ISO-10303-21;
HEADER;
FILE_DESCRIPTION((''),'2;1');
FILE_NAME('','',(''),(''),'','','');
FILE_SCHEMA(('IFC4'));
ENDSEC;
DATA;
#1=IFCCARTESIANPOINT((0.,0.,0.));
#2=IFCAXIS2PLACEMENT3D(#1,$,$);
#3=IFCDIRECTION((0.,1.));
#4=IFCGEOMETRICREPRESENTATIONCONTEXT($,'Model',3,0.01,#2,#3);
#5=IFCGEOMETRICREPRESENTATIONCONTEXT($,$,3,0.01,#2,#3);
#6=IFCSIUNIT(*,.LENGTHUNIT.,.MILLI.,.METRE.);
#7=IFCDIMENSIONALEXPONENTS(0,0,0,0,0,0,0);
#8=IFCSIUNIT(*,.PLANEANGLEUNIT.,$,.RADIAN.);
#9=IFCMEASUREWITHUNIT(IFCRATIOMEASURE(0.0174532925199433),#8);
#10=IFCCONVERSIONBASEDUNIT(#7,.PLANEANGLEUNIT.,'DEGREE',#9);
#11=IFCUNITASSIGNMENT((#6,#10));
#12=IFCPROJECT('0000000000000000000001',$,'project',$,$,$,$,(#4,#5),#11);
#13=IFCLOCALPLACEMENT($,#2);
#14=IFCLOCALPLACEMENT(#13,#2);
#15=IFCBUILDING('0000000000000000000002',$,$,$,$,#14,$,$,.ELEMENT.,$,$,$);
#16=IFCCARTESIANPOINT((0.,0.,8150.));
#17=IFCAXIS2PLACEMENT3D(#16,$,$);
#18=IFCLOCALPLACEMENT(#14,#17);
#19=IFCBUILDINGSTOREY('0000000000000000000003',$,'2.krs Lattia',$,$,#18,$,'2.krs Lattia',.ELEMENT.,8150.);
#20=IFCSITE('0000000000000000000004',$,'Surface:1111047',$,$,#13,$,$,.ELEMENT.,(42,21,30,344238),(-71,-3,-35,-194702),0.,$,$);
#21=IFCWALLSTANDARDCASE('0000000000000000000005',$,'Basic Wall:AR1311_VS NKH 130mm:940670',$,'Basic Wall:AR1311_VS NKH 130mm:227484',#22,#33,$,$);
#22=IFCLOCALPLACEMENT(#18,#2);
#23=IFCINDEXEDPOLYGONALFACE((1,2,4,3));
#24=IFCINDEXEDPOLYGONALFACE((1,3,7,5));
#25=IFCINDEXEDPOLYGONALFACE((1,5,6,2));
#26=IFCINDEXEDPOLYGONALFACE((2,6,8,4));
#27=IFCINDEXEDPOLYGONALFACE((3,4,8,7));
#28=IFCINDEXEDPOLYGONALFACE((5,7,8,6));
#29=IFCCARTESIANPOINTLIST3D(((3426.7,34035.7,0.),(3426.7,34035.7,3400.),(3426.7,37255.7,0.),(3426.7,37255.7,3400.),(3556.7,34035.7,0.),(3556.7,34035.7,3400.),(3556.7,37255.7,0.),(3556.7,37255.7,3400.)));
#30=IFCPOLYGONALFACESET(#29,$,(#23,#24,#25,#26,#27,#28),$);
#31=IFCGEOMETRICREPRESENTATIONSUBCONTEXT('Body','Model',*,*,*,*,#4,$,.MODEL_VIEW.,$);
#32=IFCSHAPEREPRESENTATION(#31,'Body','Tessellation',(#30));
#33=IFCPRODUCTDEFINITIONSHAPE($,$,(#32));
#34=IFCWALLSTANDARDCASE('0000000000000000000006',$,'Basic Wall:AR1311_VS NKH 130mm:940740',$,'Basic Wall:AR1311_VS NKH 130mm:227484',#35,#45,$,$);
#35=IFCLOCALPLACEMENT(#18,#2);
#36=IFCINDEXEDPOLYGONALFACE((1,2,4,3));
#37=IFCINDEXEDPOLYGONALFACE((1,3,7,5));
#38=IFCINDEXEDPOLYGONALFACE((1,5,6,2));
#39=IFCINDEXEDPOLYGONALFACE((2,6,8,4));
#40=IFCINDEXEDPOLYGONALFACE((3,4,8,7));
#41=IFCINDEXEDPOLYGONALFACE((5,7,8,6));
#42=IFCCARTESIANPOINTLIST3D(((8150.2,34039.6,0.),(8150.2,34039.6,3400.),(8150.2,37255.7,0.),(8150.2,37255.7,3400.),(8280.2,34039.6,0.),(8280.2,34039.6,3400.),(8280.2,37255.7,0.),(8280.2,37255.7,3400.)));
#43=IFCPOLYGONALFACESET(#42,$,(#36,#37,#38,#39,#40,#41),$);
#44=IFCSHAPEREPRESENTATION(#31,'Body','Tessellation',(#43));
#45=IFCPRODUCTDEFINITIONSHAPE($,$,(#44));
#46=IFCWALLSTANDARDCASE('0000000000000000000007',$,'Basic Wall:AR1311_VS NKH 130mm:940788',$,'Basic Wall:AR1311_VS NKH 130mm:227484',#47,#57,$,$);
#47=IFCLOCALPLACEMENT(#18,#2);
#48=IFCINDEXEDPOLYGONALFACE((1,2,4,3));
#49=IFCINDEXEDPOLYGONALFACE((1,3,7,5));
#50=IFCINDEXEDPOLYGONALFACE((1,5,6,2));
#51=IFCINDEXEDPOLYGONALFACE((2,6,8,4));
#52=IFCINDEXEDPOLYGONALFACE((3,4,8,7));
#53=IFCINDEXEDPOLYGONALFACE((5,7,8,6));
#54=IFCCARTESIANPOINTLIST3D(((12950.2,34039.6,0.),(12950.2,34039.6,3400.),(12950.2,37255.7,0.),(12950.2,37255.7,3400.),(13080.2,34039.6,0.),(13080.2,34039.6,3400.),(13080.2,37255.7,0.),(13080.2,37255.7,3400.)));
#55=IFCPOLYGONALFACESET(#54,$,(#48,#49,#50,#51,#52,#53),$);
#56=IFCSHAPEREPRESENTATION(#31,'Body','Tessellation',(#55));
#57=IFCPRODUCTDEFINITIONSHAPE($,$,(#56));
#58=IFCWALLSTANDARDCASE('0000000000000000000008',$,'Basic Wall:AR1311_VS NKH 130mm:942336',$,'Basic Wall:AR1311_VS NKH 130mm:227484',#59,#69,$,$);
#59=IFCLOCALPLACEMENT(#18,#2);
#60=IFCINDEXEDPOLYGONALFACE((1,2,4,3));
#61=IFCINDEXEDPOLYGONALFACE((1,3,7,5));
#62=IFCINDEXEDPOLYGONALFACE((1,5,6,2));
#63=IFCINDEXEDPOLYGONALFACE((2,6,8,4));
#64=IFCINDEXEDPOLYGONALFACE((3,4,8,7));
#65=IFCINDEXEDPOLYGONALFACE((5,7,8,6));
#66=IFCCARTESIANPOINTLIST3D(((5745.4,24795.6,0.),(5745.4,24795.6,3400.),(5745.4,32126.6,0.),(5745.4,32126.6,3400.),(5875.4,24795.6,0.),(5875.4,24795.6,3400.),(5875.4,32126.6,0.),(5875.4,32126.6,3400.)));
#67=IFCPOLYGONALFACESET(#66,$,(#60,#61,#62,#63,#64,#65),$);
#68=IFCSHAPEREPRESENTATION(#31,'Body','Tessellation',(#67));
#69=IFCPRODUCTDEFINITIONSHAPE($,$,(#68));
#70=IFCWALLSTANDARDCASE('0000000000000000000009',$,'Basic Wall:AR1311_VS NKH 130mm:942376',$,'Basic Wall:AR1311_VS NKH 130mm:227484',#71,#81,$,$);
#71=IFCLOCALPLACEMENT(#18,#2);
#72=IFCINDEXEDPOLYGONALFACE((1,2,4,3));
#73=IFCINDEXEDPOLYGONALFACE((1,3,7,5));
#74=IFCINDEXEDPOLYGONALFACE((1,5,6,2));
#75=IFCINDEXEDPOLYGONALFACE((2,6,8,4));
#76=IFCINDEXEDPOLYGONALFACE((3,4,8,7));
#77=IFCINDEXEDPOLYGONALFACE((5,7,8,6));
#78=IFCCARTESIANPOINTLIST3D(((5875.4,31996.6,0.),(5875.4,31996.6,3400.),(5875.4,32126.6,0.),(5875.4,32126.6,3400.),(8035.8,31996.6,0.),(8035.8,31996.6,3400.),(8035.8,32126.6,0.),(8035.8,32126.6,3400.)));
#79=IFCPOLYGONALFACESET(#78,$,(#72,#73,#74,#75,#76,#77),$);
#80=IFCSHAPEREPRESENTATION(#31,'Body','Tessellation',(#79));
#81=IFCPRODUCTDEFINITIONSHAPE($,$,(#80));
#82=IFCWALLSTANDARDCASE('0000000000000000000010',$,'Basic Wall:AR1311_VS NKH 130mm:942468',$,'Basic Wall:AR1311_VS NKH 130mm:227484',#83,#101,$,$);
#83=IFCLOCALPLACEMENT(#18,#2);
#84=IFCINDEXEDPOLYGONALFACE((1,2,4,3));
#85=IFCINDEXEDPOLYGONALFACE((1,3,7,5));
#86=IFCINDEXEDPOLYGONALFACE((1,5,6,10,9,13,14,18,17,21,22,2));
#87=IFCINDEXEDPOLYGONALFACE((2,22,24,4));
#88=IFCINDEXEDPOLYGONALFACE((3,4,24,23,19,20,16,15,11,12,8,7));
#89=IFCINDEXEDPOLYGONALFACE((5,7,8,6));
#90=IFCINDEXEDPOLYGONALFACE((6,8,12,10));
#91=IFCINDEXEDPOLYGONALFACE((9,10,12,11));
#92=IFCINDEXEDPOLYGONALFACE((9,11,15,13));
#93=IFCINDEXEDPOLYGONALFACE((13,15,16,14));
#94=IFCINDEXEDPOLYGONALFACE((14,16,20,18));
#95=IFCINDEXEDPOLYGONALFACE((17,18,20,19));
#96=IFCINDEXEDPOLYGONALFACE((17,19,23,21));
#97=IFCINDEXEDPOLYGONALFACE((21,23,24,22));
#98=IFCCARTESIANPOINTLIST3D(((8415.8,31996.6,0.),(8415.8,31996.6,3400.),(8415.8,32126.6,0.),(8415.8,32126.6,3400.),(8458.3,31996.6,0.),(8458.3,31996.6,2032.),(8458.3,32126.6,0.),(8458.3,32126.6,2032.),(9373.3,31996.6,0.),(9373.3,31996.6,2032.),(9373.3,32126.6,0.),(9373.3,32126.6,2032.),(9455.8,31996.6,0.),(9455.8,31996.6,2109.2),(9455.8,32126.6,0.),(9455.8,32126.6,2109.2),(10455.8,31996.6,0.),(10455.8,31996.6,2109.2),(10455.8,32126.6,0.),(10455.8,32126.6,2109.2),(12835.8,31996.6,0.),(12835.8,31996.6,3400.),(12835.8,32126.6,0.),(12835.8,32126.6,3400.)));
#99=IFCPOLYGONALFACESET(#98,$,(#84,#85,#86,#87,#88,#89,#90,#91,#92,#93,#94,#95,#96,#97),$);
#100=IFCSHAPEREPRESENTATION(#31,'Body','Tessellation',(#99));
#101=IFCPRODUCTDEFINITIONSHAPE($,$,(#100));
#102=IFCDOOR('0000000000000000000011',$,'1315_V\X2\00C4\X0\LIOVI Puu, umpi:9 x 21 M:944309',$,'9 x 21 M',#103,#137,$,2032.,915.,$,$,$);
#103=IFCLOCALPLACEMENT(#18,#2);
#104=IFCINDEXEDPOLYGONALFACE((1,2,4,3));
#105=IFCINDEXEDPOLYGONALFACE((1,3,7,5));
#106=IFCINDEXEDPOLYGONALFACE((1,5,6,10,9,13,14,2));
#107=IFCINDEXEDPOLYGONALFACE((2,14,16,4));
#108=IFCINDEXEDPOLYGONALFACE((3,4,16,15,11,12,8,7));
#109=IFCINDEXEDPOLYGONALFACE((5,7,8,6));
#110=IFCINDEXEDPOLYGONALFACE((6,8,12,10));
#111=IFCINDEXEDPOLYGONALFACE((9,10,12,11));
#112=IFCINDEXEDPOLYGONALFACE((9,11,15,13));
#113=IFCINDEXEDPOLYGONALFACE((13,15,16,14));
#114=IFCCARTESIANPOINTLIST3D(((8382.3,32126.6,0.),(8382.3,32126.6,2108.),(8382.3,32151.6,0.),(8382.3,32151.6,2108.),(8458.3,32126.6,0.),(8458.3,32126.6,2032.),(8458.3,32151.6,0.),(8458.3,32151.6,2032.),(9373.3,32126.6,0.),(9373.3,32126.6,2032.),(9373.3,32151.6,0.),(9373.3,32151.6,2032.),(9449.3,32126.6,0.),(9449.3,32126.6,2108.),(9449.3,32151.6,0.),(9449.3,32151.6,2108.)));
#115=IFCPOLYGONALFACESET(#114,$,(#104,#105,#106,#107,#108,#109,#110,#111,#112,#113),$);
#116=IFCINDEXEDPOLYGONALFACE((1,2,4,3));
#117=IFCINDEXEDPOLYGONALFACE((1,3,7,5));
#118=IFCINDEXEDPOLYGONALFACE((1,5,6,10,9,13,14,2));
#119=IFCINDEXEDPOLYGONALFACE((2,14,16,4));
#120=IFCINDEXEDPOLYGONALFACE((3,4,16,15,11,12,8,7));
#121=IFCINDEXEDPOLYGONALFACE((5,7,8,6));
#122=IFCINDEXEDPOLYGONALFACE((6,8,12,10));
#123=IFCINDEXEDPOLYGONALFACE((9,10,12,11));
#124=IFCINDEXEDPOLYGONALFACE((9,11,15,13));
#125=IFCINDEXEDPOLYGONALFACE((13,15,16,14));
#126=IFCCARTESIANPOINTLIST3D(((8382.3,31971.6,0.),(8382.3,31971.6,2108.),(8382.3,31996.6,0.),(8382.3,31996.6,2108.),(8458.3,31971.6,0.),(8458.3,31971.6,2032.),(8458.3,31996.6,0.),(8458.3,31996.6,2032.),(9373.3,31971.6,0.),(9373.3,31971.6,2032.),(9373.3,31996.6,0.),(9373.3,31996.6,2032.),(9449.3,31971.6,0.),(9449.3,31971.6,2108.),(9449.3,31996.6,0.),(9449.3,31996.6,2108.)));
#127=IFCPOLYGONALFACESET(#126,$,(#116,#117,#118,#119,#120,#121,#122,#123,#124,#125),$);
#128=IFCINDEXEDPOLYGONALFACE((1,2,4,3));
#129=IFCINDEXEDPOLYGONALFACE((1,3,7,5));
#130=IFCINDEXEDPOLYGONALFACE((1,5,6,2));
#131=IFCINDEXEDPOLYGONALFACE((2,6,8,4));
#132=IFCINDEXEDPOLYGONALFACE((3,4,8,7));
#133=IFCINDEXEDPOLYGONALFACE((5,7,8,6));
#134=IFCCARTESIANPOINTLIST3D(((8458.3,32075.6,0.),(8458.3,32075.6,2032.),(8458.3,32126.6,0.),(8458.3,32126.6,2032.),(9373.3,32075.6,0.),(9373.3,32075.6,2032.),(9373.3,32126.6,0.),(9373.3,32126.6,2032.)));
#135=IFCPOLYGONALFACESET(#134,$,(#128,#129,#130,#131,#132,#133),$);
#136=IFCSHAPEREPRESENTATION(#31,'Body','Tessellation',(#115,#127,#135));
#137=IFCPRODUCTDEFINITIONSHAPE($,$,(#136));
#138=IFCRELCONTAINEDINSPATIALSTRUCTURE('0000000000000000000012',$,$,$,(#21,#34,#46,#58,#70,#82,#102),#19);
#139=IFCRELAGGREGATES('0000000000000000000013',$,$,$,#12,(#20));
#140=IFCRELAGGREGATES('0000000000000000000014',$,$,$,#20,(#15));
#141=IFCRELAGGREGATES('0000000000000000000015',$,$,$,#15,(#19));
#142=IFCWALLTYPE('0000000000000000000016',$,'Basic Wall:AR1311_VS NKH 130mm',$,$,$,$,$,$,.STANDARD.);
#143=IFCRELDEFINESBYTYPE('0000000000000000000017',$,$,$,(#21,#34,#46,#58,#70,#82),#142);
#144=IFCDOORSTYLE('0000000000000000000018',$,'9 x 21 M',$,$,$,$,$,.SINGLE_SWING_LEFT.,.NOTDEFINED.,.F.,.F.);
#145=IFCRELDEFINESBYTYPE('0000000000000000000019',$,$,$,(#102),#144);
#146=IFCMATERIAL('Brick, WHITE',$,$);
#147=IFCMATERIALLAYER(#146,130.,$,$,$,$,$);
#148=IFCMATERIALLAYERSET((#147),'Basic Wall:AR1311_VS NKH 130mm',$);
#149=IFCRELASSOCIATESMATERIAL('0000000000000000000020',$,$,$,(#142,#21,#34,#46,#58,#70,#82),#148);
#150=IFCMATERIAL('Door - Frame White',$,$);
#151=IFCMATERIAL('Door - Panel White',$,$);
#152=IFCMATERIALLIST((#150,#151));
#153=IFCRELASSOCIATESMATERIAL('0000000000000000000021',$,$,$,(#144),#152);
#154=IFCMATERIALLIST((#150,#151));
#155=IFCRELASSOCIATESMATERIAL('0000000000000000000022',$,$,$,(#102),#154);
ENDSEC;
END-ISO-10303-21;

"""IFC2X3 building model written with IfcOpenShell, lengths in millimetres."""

from ifc_helpers import new_model, entity, si_unit, converted_unit, direction, frame, frame_2d, origin, place, context, subcontext, project, spatial, polyline, rectangle, outline, extrude, source, transform, mapped, material, material_list, layer, layer_set, layer_usage, type_object, type_shapes, element, fill, save


model = new_model("IFC2X3")

# Units and contexts
model_context = context("Model", 3, precision=0.01, world=origin(), true_north=direction((0.0, 1.0)))
context_of_model = context(None, 3, precision=0.01, world=origin(), true_north=direction((0.0, 1.0)))
body_context = subcontext(model_context, "Body", "Model", "MODEL_VIEW")
ifc_project = project(units=[si_unit("LENGTHUNIT", "METRE", prefix="MILLI"), converted_unit("PLANEANGLEUNIT", "DEGREE", entity("IfcRatioMeasure", 0.0174532925199433), si_unit("PLANEANGLEUNIT", "RADIAN"), dimensions=[0, 0, 0, 0, 0, 0, 0])], contexts=[model_context, context_of_model])

# Site, building, storey
site_placement = place(None, origin())
site = spatial("IfcSite", under=ifc_project, at=site_placement, Name="Surface:1111047", CompositionType="ELEMENT", RefLatitude=(42, 21, 30, 344238), RefLongitude=(-71, -3, -35, -194702), RefElevation=0.0)
building_placement = place(site_placement, origin())
building = spatial("IfcBuilding", under=site, at=building_placement, CompositionType="ELEMENT")
storey_placement = place(building_placement, frame((0.0, 0.0, 8150.0)))
storey = spatial("IfcBuildingStorey", under=building, at=storey_placement, Name="2.krs Lattia", LongName="2.krs Lattia", CompositionType="ELEMENT", Elevation=8150.0)

# Walls
ifc_material_1 = material(Name="Brick, WHITE")
ifc_layer = layer(ifc_material_1, 130.0)
ifc_layer_set = layer_set([ifc_layer], Name="Basic Wall:AR1311_VS NKH 130mm")
ifc_layer_usage_1 = layer_usage(ifc_layer_set, "AXIS2", "NEGATIVE", 65.0)
wall_type = type_object("IfcWallType", Name="Basic Wall:AR1311_VS NKH 130mm", PredefinedType="STANDARD", material=ifc_layer_set)
wall_1_placement = place(storey_placement, frame((3491.7, 37255.7, 0.0), z_axis=(0.0, 0.0, 1.0), x_axis=(0.0, -1.0, 0.0)))
element("IfcWallStandardCase", 1, at=wall_1_placement, inside=storey, type_object=wall_type, material=ifc_layer_usage_1, Name="Basic Wall:AR1311_VS NKH 130mm:940670", ObjectType="Basic Wall:AR1311_VS NKH 130mm:227484", context=body_context, shape_type="SweptSolid", body=[
    extrude(rectangle(XDim=3220.0, YDim=130.0, at=frame_2d((1610.0, 0.0), x_axis=(-1.0, 0.0))), origin(), (0.0, 0.0, 1.0), 3400.0),
])
ifc_layer_usage_2 = layer_usage(ifc_layer_set, "AXIS2", "NEGATIVE", 65.0)
wall_2_placement = place(storey_placement, frame((8215.2, 37255.7, 0.0), z_axis=(0.0, 0.0, 1.0), x_axis=(0.0, -1.0, 0.0)))
element("IfcWallStandardCase", 2, at=wall_2_placement, inside=storey, type_object=wall_type, material=ifc_layer_usage_2, Name="Basic Wall:AR1311_VS NKH 130mm:940740", ObjectType="Basic Wall:AR1311_VS NKH 130mm:227484", context=body_context, shape_type="SweptSolid", body=[
    extrude(rectangle(XDim=3216.1, YDim=130.0, at=frame_2d((1608.1, 0.0), x_axis=(-1.0, 0.0))), origin(), (0.0, 0.0, 1.0), 3400.0),
])
ifc_layer_usage_3 = layer_usage(ifc_layer_set, "AXIS2", "NEGATIVE", 65.0)
wall_3_placement = place(storey_placement, frame((13015.2, 37255.7, 0.0), z_axis=(0.0, 0.0, 1.0), x_axis=(0.0, -1.0, 0.0)))
element("IfcWallStandardCase", 3, at=wall_3_placement, inside=storey, type_object=wall_type, material=ifc_layer_usage_3, Name="Basic Wall:AR1311_VS NKH 130mm:940788", ObjectType="Basic Wall:AR1311_VS NKH 130mm:227484", context=body_context, shape_type="SweptSolid", body=[
    extrude(rectangle(XDim=3216.1, YDim=130.0, at=frame_2d((1608.1, 0.0), x_axis=(-1.0, 0.0))), origin(), (0.0, 0.0, 1.0), 3400.0),
])
ifc_layer_usage_4 = layer_usage(ifc_layer_set, "AXIS2", "NEGATIVE", 65.0)
wall_4_placement = place(storey_placement, frame((5810.4, 24795.6, 0.0), z_axis=(0.0, 0.0, 1.0), x_axis=(0.0, 1.0, 0.0)))
element("IfcWallStandardCase", 4, at=wall_4_placement, inside=storey, type_object=wall_type, material=ifc_layer_usage_4, Name="Basic Wall:AR1311_VS NKH 130mm:942336", ObjectType="Basic Wall:AR1311_VS NKH 130mm:227484", context=body_context, shape_type="SweptSolid", body=[
    extrude(rectangle(XDim=7331.0, YDim=130.0, at=frame_2d((3665.5, 0.0), x_axis=(-1.0, 0.0))), origin(), (0.0, 0.0, 1.0), 3400.0),
])
ifc_layer_usage_5 = layer_usage(ifc_layer_set, "AXIS2", "NEGATIVE", 65.0)
wall_5_placement = place(storey_placement, frame((5875.4, 32061.6, 0.0)))
element("IfcWallStandardCase", 5, at=wall_5_placement, inside=storey, type_object=wall_type, material=ifc_layer_usage_5, Name="Basic Wall:AR1311_VS NKH 130mm:942376", ObjectType="Basic Wall:AR1311_VS NKH 130mm:227484", context=body_context, shape_type="SweptSolid", body=[
    extrude(rectangle(XDim=2160.4, YDim=130.0, at=frame_2d((1080.2, 0.0), x_axis=(-1.0, 0.0))), origin(), (0.0, 0.0, 1.0), 3400.0),
])

# Wall, openings, door
ifc_layer_usage_6 = layer_usage(ifc_layer_set, "AXIS2", "NEGATIVE", 65.0)
wall_6_placement = place(storey_placement, frame((8415.8, 32061.6, 0.0)))
wall_6 = element("IfcWallStandardCase", 6, at=wall_6_placement, inside=storey, type_object=wall_type, material=ifc_layer_usage_6, Name="Basic Wall:AR1311_VS NKH 130mm:942468", ObjectType="Basic Wall:AR1311_VS NKH 130mm:227484", context=body_context, shape_type="SweptSolid", body=[
    extrude(rectangle(XDim=4420.0, YDim=130.0, at=frame_2d((2210.0, 0.0), x_axis=(-1.0, 0.0))), origin(), (0.0, 0.0, 1.0), 3400.0),
])
opening_1_placement = place(wall_6_placement, origin())
element("IfcOpeningElement", 7, at=opening_1_placement, cuts=wall_6, ObjectType="Opening", context=body_context, shape_type="SweptSolid", body=[
    extrude(rectangle(XDim=2109.2, YDim=1000.0, at=frame_2d((0.0, 0.0), x_axis=(1.0, 0.0))), frame((1540.0, -65.0, 1054.6), z_axis=(0.0, 1.0, 0.0), x_axis=(0.0, 0.0, -1.0)), (0.0, 0.0, 1.0), 130.0),
])
opening_2_placement = place(wall_6_placement, frame((42.5, -65.0, 0.0)))
opening_2 = element("IfcOpeningElement", 8, at=opening_2_placement, cuts=wall_6, ObjectType="Opening", context=body_context, shape_type="SweptSolid", body=[
    extrude(rectangle(XDim=915.0, YDim=2032.0, at=frame_2d((1016.0, 457.5), x_axis=(0.0, -1.0))), frame((0.0, 0.0, 0.0), z_axis=(0.0, 1.0, 0.0), x_axis=(0.0, 0.0, 1.0)), (0.0, 0.0, 1.0), 130.0),
])
ifc_material_2 = material(Name="Door - Frame White")
ifc_material_3 = material(Name="Door - Panel White")
ifc_material_list_1 = material_list([ifc_material_2, ifc_material_3])
ifc_material_list_2 = material_list([ifc_material_2, ifc_material_3])
door_style = type_object("IfcDoorStyle", Name="9 x 21 M", ConstructionType="NOTDEFINED", OperationType="SINGLE_SWING_LEFT", ParameterTakesPrecedence=False, Sizeable=False, material=ifc_material_list_2)
shared_shape_1 = source(origin(), body_context, "Body", "SweptSolid", [
    extrude(outline(polyline([(-533.5, -1073.0), (533.5, -1073.0), (533.5, 1035.0), (457.5, 1035.0), (457.5, -997.0), (-457.5, -997.0), (-457.5, 1035.0), (-533.5, 1035.0), (-533.5, -1073.0)])), frame((457.5, 155.0, 1035.0), z_axis=(0.0, -1.0, 0.0), x_axis=(-1.0, 0.0, 0.0)), (0.0, 0.0, 1.0), 25.0),
    extrude(outline(polyline([(-1073.0, -533.5), (1035.0, -533.5), (1035.0, -457.5), (-997.0, -457.5), (-997.0, 457.5), (1035.0, 457.5), (1035.0, 533.5), (-1073.0, 533.5), (-1073.0, -533.5)])), frame((457.5, 0.0, 1035.0), z_axis=(0.0, -1.0, 0.0), x_axis=(0.0, 0.0, -1.0)), (0.0, 0.0, 1.0), 25.0),
    extrude(rectangle(XDim=915.0, YDim=51.0, at=frame_2d((0.0, 0.0), x_axis=(1.0, 0.0))), frame((457.5, 104.5, 0.0)), (0.0, 0.0, 1.0), 2032.0),
])
type_shapes(door_style, [shared_shape_1])
door_1_placement = place(opening_2_placement, origin())
door_1 = element("IfcDoor", 9, at=door_1_placement, inside=storey, type_object=door_style, material=ifc_material_list_1, Name="1315_VÄLIOVI Puu, umpi:9 x 21 M:944309", ObjectType="9 x 21 M", OverallHeight=2032.0, OverallWidth=915.0, context=body_context, shape_type="MappedRepresentation", body=[
    mapped(shared_shape_1, transform((0.0, 0.0, 0.0), scale=1.0)),
])
fill(opening_2, door_1)

save(model, "model.ifc")
